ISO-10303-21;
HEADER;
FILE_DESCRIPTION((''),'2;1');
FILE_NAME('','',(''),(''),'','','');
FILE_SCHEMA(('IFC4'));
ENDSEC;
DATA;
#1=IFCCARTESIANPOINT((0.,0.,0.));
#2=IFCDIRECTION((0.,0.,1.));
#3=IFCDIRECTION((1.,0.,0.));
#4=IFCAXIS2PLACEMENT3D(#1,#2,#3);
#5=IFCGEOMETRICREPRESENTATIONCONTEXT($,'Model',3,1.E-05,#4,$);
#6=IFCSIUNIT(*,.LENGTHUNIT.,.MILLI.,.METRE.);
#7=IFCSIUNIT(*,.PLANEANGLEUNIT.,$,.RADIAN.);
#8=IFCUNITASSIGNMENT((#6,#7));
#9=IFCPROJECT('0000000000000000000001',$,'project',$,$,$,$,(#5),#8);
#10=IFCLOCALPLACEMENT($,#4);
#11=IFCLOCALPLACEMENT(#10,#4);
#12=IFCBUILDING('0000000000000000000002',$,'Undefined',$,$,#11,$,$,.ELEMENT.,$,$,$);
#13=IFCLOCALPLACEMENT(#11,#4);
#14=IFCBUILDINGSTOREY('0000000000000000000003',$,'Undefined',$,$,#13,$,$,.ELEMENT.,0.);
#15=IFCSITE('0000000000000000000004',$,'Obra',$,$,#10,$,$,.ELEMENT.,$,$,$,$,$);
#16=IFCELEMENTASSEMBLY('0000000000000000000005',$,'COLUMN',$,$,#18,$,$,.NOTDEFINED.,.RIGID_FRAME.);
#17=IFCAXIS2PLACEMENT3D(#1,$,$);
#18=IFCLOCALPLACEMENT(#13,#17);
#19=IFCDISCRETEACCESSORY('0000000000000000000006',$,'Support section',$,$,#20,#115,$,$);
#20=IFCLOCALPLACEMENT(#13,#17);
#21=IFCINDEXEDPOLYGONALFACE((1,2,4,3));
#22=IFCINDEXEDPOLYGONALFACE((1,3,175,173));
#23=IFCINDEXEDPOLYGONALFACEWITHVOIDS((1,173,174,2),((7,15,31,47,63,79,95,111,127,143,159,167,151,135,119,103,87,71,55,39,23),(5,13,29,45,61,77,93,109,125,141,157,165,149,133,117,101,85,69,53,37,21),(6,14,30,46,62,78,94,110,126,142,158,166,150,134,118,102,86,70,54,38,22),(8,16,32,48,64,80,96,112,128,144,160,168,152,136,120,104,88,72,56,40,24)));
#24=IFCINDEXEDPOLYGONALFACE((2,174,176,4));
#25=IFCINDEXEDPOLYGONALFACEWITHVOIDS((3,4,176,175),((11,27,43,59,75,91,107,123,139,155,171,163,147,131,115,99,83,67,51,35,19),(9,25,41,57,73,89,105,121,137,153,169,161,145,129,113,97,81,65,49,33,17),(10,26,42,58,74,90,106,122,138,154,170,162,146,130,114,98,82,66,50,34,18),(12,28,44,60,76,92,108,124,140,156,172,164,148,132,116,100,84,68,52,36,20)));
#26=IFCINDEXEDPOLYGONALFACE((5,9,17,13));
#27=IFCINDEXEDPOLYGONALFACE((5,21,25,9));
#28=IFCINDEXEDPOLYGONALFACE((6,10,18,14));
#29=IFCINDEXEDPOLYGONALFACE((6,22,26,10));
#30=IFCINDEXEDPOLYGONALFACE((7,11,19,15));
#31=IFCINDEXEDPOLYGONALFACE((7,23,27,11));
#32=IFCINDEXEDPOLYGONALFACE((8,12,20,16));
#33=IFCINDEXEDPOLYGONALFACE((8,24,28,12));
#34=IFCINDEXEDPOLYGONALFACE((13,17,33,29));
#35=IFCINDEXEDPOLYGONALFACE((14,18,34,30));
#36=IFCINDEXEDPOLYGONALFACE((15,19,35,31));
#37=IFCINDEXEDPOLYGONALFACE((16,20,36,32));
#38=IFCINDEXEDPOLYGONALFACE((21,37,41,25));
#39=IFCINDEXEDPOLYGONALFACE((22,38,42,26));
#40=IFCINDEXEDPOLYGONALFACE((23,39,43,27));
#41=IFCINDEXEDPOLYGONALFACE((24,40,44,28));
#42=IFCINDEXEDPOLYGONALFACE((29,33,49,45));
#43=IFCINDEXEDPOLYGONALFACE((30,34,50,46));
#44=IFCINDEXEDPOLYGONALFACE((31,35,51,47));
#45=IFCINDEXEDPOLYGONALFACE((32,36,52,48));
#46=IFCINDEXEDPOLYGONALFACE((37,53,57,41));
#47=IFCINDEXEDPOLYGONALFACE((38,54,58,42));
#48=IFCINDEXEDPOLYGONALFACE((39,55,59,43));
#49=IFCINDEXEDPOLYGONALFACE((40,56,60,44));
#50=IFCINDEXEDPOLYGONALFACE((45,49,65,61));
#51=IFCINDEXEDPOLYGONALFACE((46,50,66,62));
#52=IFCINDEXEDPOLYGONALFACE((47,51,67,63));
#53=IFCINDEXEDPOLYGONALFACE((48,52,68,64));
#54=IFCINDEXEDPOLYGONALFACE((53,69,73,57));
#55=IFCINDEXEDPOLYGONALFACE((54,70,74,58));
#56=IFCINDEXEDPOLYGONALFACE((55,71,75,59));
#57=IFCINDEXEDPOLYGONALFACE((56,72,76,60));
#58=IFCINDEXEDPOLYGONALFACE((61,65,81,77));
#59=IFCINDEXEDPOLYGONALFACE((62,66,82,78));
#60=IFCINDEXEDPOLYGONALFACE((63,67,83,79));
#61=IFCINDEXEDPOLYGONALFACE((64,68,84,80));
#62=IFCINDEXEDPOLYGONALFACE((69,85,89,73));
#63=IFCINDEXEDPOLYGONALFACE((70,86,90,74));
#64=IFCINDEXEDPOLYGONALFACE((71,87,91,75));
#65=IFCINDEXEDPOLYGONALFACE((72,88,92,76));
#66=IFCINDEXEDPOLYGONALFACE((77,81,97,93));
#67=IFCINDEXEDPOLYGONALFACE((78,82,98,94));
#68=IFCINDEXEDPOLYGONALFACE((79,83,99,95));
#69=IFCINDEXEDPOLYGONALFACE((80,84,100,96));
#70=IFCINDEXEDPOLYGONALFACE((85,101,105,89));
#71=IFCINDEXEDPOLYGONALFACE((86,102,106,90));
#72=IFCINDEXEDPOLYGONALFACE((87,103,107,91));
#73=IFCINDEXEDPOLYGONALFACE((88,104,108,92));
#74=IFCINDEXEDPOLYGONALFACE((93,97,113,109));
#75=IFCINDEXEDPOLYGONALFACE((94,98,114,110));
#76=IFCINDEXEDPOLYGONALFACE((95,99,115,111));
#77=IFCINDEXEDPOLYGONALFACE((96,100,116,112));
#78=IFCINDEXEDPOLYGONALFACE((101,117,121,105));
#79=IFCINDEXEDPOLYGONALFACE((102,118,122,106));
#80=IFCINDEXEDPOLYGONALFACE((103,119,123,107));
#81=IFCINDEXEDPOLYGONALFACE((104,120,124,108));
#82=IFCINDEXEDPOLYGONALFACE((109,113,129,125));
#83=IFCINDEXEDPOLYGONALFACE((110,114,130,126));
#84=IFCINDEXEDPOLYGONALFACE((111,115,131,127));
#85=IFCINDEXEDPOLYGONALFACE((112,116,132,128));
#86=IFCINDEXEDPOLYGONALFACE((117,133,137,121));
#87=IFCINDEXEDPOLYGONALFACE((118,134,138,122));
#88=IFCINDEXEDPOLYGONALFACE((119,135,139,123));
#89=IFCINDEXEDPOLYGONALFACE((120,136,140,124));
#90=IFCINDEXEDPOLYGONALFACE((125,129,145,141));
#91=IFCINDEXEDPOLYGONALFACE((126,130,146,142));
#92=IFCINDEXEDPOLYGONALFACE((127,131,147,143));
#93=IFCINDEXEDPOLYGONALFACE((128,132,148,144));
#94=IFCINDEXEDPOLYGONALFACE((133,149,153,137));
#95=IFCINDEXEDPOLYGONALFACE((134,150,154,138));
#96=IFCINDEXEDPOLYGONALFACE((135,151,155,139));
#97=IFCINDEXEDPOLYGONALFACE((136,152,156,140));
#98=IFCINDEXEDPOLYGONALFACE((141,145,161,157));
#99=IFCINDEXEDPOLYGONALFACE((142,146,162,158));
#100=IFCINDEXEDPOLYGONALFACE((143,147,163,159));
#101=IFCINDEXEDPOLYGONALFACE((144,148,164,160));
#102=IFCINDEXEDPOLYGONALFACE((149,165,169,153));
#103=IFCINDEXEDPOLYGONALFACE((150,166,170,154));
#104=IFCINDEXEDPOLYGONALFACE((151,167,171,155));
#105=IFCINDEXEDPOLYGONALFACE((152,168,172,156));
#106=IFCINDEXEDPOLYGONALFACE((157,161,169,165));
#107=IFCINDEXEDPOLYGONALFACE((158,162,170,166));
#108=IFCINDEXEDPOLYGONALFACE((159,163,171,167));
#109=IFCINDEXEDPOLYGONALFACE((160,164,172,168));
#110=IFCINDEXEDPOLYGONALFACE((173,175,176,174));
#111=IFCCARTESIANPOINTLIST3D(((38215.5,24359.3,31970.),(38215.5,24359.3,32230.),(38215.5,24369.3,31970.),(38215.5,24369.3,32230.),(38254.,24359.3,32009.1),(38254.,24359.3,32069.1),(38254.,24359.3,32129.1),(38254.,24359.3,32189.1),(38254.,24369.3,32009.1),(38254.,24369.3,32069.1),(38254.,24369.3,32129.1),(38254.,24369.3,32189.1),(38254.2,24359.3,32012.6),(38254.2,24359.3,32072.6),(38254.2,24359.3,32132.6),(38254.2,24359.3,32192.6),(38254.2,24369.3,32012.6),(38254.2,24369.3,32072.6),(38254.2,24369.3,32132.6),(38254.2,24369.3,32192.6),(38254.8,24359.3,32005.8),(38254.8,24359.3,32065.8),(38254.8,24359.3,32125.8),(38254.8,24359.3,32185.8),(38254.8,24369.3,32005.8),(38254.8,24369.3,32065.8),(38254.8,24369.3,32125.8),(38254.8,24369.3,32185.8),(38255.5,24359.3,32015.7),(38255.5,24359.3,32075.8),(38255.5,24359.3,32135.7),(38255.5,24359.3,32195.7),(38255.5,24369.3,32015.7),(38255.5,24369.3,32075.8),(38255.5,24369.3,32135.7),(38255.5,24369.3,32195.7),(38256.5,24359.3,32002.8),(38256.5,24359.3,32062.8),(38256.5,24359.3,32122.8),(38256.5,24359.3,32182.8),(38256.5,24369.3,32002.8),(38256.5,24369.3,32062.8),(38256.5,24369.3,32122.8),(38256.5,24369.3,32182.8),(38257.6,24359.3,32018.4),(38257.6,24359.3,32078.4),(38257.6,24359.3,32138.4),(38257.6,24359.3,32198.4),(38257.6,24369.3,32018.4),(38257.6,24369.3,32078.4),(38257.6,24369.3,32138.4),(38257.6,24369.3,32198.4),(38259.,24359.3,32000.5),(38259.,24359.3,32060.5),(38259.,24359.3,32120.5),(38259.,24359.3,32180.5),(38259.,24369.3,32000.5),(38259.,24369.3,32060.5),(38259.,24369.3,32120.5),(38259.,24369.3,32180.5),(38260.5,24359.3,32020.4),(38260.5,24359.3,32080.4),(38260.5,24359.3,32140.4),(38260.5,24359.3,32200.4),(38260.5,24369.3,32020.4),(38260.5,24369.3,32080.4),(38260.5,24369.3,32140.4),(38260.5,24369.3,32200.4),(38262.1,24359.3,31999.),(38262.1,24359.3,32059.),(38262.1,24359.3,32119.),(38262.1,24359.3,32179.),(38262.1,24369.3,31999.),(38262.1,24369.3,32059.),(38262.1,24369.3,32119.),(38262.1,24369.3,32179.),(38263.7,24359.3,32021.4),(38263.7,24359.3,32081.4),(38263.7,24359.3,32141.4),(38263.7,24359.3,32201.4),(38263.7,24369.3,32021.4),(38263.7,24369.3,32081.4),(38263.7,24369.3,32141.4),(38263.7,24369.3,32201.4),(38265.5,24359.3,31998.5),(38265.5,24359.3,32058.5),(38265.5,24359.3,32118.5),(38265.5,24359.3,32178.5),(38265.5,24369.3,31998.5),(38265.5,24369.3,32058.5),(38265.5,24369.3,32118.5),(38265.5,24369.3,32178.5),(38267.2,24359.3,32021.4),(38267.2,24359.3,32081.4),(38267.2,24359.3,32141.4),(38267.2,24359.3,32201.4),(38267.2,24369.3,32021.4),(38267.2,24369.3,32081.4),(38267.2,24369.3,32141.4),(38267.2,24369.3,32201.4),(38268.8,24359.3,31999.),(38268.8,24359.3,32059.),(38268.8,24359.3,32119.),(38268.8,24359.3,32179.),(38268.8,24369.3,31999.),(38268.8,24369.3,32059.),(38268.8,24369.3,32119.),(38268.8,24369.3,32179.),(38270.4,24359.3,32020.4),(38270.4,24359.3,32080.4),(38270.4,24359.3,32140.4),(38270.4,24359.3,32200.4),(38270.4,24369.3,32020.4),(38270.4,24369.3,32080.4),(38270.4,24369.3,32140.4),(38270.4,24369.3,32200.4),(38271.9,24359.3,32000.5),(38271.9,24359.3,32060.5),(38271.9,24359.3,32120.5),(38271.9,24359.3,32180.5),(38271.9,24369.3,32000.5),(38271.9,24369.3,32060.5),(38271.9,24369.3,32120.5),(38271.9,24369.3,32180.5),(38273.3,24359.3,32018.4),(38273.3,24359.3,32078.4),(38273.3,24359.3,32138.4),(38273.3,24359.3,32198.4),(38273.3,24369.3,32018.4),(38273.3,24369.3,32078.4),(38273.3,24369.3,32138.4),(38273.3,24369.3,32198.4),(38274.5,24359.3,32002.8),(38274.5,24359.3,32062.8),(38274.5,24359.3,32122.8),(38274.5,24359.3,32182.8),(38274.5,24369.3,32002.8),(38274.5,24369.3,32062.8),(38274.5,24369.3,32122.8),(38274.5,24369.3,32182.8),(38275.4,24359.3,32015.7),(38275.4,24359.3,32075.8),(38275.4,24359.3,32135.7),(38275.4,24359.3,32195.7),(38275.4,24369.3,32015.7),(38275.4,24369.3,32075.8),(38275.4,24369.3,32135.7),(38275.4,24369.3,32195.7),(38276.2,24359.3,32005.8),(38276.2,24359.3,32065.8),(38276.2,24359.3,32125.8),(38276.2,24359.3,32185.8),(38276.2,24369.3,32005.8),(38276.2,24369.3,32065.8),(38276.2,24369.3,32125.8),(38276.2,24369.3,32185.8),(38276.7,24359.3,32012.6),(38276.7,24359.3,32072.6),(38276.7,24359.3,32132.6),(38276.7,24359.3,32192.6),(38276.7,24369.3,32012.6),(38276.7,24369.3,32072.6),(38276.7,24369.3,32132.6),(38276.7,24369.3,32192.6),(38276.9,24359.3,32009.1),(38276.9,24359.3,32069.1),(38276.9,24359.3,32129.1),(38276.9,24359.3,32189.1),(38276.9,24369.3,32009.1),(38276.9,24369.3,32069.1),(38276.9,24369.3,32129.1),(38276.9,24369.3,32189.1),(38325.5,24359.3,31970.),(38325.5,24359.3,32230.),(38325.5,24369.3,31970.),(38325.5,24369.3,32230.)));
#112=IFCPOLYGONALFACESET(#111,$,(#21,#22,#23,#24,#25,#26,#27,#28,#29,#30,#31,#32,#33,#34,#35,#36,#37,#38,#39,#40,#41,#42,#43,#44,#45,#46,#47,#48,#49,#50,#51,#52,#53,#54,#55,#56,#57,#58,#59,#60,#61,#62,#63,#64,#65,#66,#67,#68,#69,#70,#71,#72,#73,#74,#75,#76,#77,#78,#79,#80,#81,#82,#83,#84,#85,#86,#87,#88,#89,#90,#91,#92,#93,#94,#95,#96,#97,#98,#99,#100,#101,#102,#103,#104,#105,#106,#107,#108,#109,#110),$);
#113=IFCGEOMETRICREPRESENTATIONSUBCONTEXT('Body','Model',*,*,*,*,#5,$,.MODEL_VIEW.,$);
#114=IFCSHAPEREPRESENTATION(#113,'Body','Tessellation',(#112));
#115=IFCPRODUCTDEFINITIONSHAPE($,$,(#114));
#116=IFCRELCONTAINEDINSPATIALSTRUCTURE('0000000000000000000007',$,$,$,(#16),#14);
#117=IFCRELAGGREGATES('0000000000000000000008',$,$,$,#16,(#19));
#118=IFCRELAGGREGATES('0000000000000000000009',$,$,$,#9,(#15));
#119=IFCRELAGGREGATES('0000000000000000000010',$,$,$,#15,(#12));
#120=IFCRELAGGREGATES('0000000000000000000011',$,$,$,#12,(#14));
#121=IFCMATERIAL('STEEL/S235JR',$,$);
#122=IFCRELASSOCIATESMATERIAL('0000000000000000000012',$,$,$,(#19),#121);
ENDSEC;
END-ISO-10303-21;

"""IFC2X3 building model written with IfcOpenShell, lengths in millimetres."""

from ifc_helpers import new_model, si_unit, frame, origin_with_axes, origin_2d_with_axis, place, context, subcontext, project, spatial, rectangle, circle, extrude, source, transform, mapped, material, element, aggregate, save


model = new_model("IFC2X3")

# Units and contexts
model_context = context("Model", 3, precision=1e-05, world=origin_with_axes())
body_context = subcontext(model_context, "Body", "Model", "MODEL_VIEW")
ifc_project = project(units=[si_unit("LENGTHUNIT", "METRE", prefix="MILLI"), si_unit("PLANEANGLEUNIT", "RADIAN")], contexts=[model_context])

# Site, building, storey
site_placement = place(None, origin_with_axes())
site = spatial("IfcSite", under=ifc_project, at=site_placement, Name="Obra", CompositionType="ELEMENT")
building_placement = place(site_placement, origin_with_axes())
building = spatial("IfcBuilding", under=site, at=building_placement, Name="Undefined", CompositionType="ELEMENT")
storey_placement = place(building_placement, origin_with_axes())
storey = spatial("IfcBuildingStorey", under=building, at=storey_placement, Name="Undefined", CompositionType="ELEMENT", Elevation=0.0)

# Shared definitions
ifc_material_1 = material(Name="STEEL/S235JR")

# Shared definitions
shared_shape_1 = source(origin_with_axes(), body_context, "Body", "SweptSolid", [
    extrude(circle(Radius=11.5, at=origin_2d_with_axis()), frame((0.0, -14.4, 0.0), z_axis=(0.0, 1.0, 0.0), x_axis=(1.0, 0.0, 0.0)), (0.0, 0.0, 1.0), 10.2),
])

# Element assembly, discrete accessory, opening
assembly_1_placement = place(storey_placement, origin_with_axes())
assembly_1 = element("IfcElementAssembly", 1, at=assembly_1_placement, inside=storey, Name="COLUMN", AssemblyPlace="NOTDEFINED", PredefinedType="RIGID_FRAME")
discrete_accessory_1_placement = place(assembly_1_placement, frame((38270.5, 24364.3, 31970.0), z_axis=(0.0, 0.0, 1.0), x_axis=(1.0, 0.0, 0.0)))
discrete_accessory_1 = element("IfcDiscreteAccessory", 2, at=discrete_accessory_1_placement, material=ifc_material_1, Name="Support section", context=body_context, shape_type="SweptSolid", body=[
    extrude(rectangle(XDim=10.0, YDim=110.0, at=origin_2d_with_axis()), frame((0.0, 0.0, 260.0), z_axis=(0.0, 0.0, -1.0), x_axis=(0.0, 1.0, 0.0)), (0.0, 0.0, 1.0), 260.0),
])
opening_1_placement = place(assembly_1_placement, frame((38315.5, 24355.0, 32300.0), z_axis=(-1.0, 0.0, 0.0), x_axis=(0.0, 0.0, -1.0)))
element("IfcOpeningElement", 3, at=opening_1_placement, cuts=discrete_accessory_1, ObjectType="Opening", context=body_context, shape_type="MappedRepresentation", body=[
    mapped(shared_shape_1, transform((110.0, 0.0, 50.0))),
    mapped(shared_shape_1, transform((170.0, 0.0, 50.0))),
    mapped(shared_shape_1, transform((230.0, 0.0, 50.0))),
    mapped(shared_shape_1, transform((290.0, 0.0, 50.0))),
])
aggregate(assembly_1, [discrete_accessory_1])

save(model, "model.ifc")
